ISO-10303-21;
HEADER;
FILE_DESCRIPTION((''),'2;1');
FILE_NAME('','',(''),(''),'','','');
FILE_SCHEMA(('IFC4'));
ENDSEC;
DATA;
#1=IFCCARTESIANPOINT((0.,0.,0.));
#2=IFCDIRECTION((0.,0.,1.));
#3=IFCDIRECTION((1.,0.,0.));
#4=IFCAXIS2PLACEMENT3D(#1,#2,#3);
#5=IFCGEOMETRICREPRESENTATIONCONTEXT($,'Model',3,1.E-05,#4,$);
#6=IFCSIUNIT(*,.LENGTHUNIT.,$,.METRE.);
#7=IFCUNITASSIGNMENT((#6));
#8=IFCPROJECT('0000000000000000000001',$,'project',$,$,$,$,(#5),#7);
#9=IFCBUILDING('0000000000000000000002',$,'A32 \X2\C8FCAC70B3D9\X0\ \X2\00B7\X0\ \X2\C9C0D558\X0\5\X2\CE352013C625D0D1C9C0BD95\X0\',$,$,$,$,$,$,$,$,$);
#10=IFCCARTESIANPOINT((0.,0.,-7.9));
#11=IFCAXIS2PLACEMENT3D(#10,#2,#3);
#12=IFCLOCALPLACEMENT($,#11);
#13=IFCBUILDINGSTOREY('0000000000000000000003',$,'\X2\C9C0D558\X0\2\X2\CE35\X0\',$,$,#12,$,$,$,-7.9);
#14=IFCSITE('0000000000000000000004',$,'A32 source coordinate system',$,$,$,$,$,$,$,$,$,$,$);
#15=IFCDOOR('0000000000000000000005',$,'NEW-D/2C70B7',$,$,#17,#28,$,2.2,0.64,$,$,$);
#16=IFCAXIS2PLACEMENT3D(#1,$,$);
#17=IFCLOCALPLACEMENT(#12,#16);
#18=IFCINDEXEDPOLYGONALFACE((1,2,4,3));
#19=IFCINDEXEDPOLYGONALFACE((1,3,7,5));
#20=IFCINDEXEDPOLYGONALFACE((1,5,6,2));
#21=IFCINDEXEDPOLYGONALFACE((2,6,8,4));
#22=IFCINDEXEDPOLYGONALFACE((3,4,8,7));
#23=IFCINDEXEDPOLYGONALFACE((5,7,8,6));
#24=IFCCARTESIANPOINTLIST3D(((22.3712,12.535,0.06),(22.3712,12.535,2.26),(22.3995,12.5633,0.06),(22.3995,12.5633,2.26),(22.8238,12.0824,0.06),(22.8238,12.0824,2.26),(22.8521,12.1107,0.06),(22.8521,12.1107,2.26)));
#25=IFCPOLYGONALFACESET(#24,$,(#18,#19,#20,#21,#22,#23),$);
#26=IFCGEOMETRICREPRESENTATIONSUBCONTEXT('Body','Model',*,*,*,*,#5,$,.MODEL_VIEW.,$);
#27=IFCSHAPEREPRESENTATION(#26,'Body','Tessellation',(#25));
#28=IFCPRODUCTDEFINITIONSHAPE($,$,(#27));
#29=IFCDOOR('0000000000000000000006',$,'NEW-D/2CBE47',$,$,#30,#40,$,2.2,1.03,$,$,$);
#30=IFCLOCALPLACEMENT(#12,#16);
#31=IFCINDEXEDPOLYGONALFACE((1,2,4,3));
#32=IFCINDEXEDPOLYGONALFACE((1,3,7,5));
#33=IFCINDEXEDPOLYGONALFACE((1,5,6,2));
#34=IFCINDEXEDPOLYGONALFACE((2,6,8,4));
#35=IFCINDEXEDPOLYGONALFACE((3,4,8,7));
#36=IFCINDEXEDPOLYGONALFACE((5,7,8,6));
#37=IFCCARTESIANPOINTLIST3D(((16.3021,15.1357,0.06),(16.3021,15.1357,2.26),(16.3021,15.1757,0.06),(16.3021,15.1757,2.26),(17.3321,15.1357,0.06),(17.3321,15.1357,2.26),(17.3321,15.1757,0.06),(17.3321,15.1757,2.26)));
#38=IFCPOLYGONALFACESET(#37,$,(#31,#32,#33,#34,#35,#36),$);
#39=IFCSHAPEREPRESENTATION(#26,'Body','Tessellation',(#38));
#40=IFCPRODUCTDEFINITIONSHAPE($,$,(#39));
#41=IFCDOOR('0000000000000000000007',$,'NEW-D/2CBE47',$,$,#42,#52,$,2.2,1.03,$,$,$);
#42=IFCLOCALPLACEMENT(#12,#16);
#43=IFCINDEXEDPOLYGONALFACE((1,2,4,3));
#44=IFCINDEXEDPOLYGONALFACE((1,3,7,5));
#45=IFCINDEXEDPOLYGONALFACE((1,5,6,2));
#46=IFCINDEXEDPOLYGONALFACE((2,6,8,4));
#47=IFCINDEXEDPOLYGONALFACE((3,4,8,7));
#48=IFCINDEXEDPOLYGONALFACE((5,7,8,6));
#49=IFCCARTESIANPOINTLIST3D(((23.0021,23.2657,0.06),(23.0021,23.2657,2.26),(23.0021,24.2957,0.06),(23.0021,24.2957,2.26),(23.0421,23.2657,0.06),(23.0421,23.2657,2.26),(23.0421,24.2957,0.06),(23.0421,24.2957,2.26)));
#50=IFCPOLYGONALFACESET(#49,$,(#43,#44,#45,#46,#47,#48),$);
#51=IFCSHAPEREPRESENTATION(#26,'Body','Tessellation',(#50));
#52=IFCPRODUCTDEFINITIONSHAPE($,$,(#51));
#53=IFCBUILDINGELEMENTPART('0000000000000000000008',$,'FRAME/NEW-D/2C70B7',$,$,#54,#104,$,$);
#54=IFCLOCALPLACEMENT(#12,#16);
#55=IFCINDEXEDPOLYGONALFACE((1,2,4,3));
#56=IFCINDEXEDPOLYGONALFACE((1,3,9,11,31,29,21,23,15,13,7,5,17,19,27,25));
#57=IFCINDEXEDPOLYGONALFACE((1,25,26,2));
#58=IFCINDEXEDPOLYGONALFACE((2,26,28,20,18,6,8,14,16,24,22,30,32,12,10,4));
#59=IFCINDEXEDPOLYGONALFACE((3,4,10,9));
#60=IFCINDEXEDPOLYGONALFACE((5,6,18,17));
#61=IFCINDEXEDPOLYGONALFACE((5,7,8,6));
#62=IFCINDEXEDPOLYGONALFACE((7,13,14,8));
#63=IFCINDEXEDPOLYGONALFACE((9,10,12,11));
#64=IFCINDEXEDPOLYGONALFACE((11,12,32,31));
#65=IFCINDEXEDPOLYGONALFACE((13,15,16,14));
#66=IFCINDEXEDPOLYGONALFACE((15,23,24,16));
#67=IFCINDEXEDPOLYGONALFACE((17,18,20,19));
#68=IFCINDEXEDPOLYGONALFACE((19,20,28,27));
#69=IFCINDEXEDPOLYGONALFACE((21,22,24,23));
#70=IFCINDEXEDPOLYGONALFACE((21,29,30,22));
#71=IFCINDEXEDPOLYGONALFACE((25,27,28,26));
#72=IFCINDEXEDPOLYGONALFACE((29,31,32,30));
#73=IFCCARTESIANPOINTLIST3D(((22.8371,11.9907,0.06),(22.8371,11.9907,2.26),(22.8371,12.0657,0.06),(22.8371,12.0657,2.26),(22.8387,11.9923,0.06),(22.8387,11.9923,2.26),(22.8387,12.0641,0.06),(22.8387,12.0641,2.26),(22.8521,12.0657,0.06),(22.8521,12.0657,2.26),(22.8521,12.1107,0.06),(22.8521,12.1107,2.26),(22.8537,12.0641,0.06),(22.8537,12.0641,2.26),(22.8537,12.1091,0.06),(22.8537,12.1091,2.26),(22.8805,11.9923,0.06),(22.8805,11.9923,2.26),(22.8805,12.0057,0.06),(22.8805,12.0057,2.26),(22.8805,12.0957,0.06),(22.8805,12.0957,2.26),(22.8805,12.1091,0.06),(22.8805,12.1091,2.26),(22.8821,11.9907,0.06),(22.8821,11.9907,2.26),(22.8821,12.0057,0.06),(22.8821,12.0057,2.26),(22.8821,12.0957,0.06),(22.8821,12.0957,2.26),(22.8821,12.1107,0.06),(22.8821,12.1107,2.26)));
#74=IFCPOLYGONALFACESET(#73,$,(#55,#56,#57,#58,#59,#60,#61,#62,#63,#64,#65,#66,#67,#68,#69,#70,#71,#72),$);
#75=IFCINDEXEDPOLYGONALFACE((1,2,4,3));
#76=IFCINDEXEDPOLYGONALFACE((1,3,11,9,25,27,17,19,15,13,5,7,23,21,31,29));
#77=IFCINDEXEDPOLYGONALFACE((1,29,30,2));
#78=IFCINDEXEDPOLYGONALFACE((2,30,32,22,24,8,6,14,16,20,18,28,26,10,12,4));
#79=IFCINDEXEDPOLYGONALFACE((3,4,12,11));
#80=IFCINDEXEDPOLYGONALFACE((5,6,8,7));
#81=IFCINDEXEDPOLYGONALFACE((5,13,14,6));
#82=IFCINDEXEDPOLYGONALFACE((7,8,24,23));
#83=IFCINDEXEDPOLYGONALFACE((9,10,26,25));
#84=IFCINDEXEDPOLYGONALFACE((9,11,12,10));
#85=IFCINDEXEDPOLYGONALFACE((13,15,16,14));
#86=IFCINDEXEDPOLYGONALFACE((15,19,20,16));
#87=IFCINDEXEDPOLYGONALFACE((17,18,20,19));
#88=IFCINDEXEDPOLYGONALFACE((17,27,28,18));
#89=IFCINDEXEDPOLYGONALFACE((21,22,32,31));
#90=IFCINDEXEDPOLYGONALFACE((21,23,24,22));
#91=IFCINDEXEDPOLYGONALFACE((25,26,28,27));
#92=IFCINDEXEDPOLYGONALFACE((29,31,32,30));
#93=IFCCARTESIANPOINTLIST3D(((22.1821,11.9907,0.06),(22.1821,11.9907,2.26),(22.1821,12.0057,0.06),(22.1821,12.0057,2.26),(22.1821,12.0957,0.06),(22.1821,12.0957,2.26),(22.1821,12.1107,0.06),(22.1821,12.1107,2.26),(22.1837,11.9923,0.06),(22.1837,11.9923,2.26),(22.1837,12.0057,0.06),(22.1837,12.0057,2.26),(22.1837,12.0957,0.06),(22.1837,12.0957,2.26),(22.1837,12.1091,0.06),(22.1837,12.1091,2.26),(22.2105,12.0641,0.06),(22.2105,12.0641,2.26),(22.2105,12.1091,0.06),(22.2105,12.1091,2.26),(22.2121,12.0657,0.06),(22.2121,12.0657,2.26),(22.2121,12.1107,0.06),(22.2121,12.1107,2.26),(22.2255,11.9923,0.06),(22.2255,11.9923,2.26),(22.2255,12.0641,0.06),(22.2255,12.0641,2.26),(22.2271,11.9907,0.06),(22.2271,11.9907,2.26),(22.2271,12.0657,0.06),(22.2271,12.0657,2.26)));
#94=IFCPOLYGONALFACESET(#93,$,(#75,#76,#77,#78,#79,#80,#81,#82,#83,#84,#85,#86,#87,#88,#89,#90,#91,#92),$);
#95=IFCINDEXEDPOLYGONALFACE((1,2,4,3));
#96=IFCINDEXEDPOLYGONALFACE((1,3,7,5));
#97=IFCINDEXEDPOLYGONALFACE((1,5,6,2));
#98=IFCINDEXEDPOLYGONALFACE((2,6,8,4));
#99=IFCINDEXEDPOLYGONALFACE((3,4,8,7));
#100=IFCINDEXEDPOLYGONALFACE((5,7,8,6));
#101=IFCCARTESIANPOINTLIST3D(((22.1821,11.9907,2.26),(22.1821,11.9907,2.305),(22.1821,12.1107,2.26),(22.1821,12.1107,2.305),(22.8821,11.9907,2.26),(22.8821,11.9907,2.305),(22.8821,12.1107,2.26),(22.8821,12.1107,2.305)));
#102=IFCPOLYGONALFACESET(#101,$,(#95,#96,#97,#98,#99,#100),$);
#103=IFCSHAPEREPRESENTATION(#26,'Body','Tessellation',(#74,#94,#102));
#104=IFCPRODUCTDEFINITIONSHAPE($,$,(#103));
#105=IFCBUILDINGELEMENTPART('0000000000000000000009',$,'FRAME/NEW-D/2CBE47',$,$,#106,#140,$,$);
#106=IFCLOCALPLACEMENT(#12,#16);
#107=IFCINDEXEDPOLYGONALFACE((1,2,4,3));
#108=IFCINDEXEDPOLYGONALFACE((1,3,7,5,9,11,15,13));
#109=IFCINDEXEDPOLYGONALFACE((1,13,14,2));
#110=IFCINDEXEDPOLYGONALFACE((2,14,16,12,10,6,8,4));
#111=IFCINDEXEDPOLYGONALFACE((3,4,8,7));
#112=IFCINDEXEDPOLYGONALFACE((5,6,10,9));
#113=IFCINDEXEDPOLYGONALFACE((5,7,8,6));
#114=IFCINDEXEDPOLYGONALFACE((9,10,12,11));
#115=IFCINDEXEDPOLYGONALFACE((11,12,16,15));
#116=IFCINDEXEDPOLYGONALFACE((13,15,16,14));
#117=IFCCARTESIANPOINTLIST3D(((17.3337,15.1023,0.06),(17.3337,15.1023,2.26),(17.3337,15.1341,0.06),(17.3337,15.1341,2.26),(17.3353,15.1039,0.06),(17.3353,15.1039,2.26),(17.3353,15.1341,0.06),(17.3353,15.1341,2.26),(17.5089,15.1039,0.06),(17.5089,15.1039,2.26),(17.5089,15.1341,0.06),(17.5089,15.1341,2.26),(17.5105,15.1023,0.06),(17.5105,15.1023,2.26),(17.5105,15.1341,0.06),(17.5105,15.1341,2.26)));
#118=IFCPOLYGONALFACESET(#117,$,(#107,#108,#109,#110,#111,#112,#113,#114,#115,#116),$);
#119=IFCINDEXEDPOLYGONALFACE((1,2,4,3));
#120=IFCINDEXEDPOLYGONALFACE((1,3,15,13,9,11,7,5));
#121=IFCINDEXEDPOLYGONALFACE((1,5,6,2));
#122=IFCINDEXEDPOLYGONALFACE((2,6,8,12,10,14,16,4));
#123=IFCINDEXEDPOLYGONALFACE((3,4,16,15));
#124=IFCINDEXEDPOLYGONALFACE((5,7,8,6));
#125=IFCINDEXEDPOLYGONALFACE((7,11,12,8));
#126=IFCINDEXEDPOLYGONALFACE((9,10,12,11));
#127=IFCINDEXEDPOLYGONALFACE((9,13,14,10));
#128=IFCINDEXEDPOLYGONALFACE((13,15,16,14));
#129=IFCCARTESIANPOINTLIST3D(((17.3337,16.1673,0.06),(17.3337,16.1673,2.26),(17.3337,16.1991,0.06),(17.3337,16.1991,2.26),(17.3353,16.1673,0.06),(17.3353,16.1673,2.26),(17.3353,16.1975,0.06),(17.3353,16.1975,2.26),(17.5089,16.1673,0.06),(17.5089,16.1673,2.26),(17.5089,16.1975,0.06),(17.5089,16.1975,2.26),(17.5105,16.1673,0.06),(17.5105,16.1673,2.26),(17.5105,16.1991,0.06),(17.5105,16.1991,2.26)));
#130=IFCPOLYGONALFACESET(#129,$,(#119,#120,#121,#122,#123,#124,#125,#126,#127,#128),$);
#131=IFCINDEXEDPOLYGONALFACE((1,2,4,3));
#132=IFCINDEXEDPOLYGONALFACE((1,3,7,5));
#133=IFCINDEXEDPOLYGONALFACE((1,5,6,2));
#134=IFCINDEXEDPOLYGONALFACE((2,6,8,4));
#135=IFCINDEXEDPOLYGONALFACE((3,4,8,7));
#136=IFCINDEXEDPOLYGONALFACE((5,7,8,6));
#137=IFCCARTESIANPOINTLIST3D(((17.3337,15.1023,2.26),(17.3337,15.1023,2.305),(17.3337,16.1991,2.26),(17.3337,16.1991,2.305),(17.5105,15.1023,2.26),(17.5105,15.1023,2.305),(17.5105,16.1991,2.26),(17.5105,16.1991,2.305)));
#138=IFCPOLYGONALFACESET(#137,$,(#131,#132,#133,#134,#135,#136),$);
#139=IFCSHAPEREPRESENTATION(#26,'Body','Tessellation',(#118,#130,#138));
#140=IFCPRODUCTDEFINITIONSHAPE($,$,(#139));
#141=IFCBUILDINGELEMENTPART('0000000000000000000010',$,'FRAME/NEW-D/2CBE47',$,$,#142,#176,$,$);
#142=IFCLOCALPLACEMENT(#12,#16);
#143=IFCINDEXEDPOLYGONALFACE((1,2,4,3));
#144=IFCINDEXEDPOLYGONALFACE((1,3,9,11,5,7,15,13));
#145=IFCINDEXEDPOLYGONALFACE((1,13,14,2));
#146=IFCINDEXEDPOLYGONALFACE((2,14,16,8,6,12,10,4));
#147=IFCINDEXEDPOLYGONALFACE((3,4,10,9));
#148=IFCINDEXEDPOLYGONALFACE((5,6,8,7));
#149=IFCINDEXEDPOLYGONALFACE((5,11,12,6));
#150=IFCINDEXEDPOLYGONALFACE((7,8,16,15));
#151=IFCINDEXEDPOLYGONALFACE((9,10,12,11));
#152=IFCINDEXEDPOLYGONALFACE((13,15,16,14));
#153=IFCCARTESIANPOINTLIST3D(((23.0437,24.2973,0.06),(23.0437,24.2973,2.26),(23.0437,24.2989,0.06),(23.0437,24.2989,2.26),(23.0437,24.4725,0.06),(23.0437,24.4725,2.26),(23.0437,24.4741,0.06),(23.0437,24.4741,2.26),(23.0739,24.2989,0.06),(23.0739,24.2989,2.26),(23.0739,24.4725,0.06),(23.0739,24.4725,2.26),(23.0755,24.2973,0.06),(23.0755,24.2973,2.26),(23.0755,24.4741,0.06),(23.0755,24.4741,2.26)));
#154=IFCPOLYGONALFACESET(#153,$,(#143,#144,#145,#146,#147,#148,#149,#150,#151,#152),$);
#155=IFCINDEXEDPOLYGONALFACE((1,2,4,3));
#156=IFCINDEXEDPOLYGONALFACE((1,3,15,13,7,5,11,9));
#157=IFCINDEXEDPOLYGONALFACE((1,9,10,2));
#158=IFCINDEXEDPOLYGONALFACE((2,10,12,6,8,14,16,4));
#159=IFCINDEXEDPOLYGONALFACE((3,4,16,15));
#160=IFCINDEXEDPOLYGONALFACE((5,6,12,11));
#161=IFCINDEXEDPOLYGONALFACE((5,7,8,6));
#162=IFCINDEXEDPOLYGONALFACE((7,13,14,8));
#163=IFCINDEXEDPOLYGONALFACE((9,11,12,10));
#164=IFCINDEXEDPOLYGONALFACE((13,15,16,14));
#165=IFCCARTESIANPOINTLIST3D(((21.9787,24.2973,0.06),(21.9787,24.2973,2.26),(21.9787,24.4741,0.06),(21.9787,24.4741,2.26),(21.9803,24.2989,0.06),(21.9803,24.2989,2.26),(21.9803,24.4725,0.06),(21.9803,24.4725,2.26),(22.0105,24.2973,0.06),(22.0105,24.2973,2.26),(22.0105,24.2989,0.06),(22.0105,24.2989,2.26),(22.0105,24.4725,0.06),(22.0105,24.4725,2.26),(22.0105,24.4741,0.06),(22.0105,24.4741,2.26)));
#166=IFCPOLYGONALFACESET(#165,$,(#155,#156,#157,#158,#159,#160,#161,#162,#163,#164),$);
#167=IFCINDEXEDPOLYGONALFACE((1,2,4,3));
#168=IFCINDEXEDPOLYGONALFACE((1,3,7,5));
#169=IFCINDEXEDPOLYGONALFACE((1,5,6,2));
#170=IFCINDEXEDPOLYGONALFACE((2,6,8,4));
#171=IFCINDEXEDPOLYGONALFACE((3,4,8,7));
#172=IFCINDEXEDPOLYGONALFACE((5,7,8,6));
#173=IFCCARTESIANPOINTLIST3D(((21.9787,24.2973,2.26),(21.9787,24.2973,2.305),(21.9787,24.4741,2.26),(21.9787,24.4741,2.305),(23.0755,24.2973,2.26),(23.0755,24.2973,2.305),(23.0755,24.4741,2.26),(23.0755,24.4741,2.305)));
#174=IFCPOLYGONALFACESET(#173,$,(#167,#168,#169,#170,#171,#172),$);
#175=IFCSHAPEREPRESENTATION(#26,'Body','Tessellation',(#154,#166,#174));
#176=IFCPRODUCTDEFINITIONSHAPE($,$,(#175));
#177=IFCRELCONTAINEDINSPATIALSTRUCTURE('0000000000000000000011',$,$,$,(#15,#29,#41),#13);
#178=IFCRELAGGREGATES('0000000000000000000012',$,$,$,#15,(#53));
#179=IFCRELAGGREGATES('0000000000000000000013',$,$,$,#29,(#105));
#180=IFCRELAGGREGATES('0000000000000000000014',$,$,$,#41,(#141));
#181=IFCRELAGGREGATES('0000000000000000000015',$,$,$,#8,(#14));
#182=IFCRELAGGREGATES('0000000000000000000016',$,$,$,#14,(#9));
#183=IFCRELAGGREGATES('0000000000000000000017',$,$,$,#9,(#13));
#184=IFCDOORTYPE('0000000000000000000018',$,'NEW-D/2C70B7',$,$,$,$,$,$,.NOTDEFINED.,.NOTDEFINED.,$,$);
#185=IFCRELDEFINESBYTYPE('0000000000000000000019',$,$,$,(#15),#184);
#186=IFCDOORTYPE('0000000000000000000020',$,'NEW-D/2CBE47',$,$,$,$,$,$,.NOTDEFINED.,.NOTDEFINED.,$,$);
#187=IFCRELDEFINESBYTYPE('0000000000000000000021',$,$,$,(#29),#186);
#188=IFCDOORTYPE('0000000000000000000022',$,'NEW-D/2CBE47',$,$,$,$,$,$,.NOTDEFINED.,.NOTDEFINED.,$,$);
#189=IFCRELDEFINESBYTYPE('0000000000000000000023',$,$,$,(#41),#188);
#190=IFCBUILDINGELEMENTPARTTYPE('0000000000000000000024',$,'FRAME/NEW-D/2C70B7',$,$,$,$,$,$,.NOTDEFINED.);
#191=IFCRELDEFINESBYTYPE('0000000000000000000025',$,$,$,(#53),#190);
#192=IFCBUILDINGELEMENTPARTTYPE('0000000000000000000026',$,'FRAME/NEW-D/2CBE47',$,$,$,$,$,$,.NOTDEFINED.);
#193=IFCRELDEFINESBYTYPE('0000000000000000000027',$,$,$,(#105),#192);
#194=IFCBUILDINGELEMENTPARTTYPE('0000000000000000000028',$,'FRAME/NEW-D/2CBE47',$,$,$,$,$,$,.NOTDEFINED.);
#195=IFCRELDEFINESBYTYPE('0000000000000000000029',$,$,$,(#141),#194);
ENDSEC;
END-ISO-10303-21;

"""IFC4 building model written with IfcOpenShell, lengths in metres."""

from ifc_helpers import new_model, si_unit, frame, origin, origin_with_axes, place, context, subcontext, project, spatial, polyline, outline, extrude, source, transform, mapped, type_object, type_shapes, element, aggregate, save


model = new_model("IFC4")

# Units and contexts
model_context = context("Model", 3, precision=1e-05, world=origin_with_axes())
body_context = subcontext(model_context, "Body", "Model", "MODEL_VIEW")
ifc_project = project(units=[si_unit("LENGTHUNIT", "METRE")], contexts=[model_context])

# Site, building, storey
site = spatial("IfcSite", under=ifc_project, Name="A32 source coordinate system")
building = spatial("IfcBuilding", under=site, Name="A32 주거동 · 지하5층–옥탑지붕")
storey_placement = place(None, frame((0.0, 0.0, -7.9), z_axis=(0.0, 0.0, 1.0), x_axis=(1.0, 0.0, 0.0)))
storey = spatial("IfcBuildingStorey", under=building, at=storey_placement, Name="지하2층", Elevation=-7.9)

# Doors
door_type_1 = type_object("IfcDoorType", Name="NEW-D/2C70B7", OperationType="NOTDEFINED", PredefinedType="NOTDEFINED")
shared_shape_1 = source(origin(), body_context, "Body", "SweptSolid", [
    extrude(outline(polyline([(22.8521, 12.1107), (22.8238, 12.0824), (22.3712, 12.535), (22.3995, 12.5633), (22.8521, 12.1107)])), frame((0.0, 0.0, 0.06)), (0.0, 0.0, 1.0), 2.2),
])
type_shapes(door_type_1, [shared_shape_1])
door_1_placement = place(storey_placement, origin_with_axes())
door_1 = element("IfcDoor", 1, at=door_1_placement, inside=storey, type_object=door_type_1, Name="NEW-D/2C70B7", OverallHeight=2.2, OverallWidth=0.64, context=body_context, shape_type="MappedRepresentation", body=[
    mapped(shared_shape_1, transform((0.0, 0.0, 0.0), scale=1.0)),
])
door_type_2 = type_object("IfcDoorType", Name="NEW-D/2CBE47", OperationType="NOTDEFINED", PredefinedType="NOTDEFINED")
shared_shape_2 = source(origin(), body_context, "Body", "SweptSolid", [
    extrude(outline(polyline([(16.3021, 15.1757), (17.3321, 15.1757), (17.3321, 15.1357), (16.3021, 15.1357), (16.3021, 15.1757)])), frame((0.0, 0.0, 0.06)), (0.0, 0.0, 1.0), 2.2),
])
type_shapes(door_type_2, [shared_shape_2])
door_2_placement = place(storey_placement, origin_with_axes())
door_2 = element("IfcDoor", 2, at=door_2_placement, inside=storey, type_object=door_type_2, Name="NEW-D/2CBE47", OverallHeight=2.2, OverallWidth=1.03, context=body_context, shape_type="MappedRepresentation", body=[
    mapped(shared_shape_2, transform((0.0, 0.0, 0.0), scale=1.0)),
])
door_type_3 = type_object("IfcDoorType", Name="NEW-D/2CBE47", OperationType="NOTDEFINED", PredefinedType="NOTDEFINED")
shared_shape_3 = source(origin(), body_context, "Body", "SweptSolid", [
    extrude(outline(polyline([(23.0021, 23.2657), (23.0021, 24.2957), (23.0421, 24.2957), (23.0421, 23.2657), (23.0021, 23.2657)])), frame((0.0, 0.0, 0.06)), (0.0, 0.0, 1.0), 2.2),
])
type_shapes(door_type_3, [shared_shape_3])
door_3_placement = place(storey_placement, origin_with_axes())
door_3 = element("IfcDoor", 3, at=door_3_placement, inside=storey, type_object=door_type_3, Name="NEW-D/2CBE47", OverallHeight=2.2, OverallWidth=1.03, context=body_context, shape_type="MappedRepresentation", body=[
    mapped(shared_shape_3, transform((0.0, 0.0, 0.0), scale=1.0)),
])

# Building element parts
building_element_part_type_1 = type_object("IfcBuildingElementPartType", Name="FRAME/NEW-D/2C70B7", PredefinedType="NOTDEFINED")
shared_shape_4 = source(origin(), body_context, "Body", "SweptSolid", [
    extrude(outline(polyline([(22.8537, 12.1091), (22.8537, 12.0641), (22.8387, 12.0641), (22.8387, 11.9923), (22.8805, 11.9923), (22.8805, 12.0057), (22.8821, 12.0057), (22.8821, 11.9907), (22.8371, 11.9907), (22.8371, 12.0657), (22.8521, 12.0657), (22.8521, 12.1107), (22.8821, 12.1107), (22.8821, 12.0957), (22.8805, 12.0957), (22.8805, 12.1091), (22.8537, 12.1091)])), frame((0.0, 0.0, 0.06)), (0.0, 0.0, 1.0), 2.2),
    extrude(outline(polyline([(22.1821, 12.1107), (22.2121, 12.1107), (22.2121, 12.0657), (22.2271, 12.0657), (22.2271, 11.9907), (22.1821, 11.9907), (22.1821, 12.0057), (22.1837, 12.0057), (22.1837, 11.9923), (22.2255, 11.9923), (22.2255, 12.0641), (22.2105, 12.0641), (22.2105, 12.1091), (22.1837, 12.1091), (22.1837, 12.0957), (22.1821, 12.0957), (22.1821, 12.1107)])), frame((0.0, 0.0, 0.06)), (0.0, 0.0, 1.0), 2.2),
    extrude(outline(polyline([(22.8821, 11.9907), (22.8821, 12.1107), (22.1821, 12.1107), (22.1821, 11.9907), (22.8821, 11.9907)])), frame((0.0, 0.0, 2.26)), (0.0, 0.0, 1.0), 0.045),
])
type_shapes(building_element_part_type_1, [shared_shape_4])
building_element_part_1_placement = place(door_1_placement, origin_with_axes())
building_element_part_1 = element("IfcBuildingElementPart", 4, at=building_element_part_1_placement, type_object=building_element_part_type_1, Name="FRAME/NEW-D/2C70B7", context=body_context, shape_type="MappedRepresentation", body=[
    mapped(shared_shape_4, transform((0.0, 0.0, 0.0), scale=1.0)),
])
aggregate(door_1, [building_element_part_1])
building_element_part_type_2 = type_object("IfcBuildingElementPartType", Name="FRAME/NEW-D/2CBE47", PredefinedType="NOTDEFINED")
shared_shape_5 = source(origin(), body_context, "Body", "SweptSolid", [
    extrude(outline(polyline([(17.3353, 15.1039), (17.5089, 15.1039), (17.5089, 15.1341), (17.5105, 15.1341), (17.5105, 15.1023), (17.3337, 15.1023), (17.3337, 15.1341), (17.3353, 15.1341), (17.3353, 15.1039)])), frame((0.0, 0.0, 0.06)), (0.0, 0.0, 1.0), 2.2),
    extrude(outline(polyline([(17.5105, 16.1991), (17.5105, 16.1673), (17.5089, 16.1673), (17.5089, 16.1975), (17.3353, 16.1975), (17.3353, 16.1673), (17.3337, 16.1673), (17.3337, 16.1991), (17.5105, 16.1991)])), frame((0.0, 0.0, 0.06)), (0.0, 0.0, 1.0), 2.2),
    extrude(outline(polyline([(17.5105, 15.1023), (17.5105, 16.1991), (17.3337, 16.1991), (17.3337, 15.1023), (17.5105, 15.1023)])), frame((0.0, 0.0, 2.26)), (0.0, 0.0, 1.0), 0.045),
])
type_shapes(building_element_part_type_2, [shared_shape_5])
building_element_part_2_placement = place(door_2_placement, origin_with_axes())
building_element_part_2 = element("IfcBuildingElementPart", 5, at=building_element_part_2_placement, type_object=building_element_part_type_2, Name="FRAME/NEW-D/2CBE47", context=body_context, shape_type="MappedRepresentation", body=[
    mapped(shared_shape_5, transform((0.0, 0.0, 0.0), scale=1.0)),
])
aggregate(door_2, [building_element_part_2])
building_element_part_type_3 = type_object("IfcBuildingElementPartType", Name="FRAME/NEW-D/2CBE47", PredefinedType="NOTDEFINED")
shared_shape_6 = source(origin(), body_context, "Body", "SweptSolid", [
    extrude(outline(polyline([(23.0739, 24.2989), (23.0739, 24.4725), (23.0437, 24.4725), (23.0437, 24.4741), (23.0755, 24.4741), (23.0755, 24.2973), (23.0437, 24.2973), (23.0437, 24.2989), (23.0739, 24.2989)])), frame((0.0, 0.0, 0.06)), (0.0, 0.0, 1.0), 2.2),
    extrude(outline(polyline([(21.9787, 24.4741), (22.0105, 24.4741), (22.0105, 24.4725), (21.9803, 24.4725), (21.9803, 24.2989), (22.0105, 24.2989), (22.0105, 24.2973), (21.9787, 24.2973), (21.9787, 24.4741)])), frame((0.0, 0.0, 0.06)), (0.0, 0.0, 1.0), 2.2),
    extrude(outline(polyline([(23.0755, 24.2973), (23.0755, 24.4741), (21.9787, 24.4741), (21.9787, 24.2973), (23.0755, 24.2973)])), frame((0.0, 0.0, 2.26)), (0.0, 0.0, 1.0), 0.045),
])
type_shapes(building_element_part_type_3, [shared_shape_6])
building_element_part_3_placement = place(door_3_placement, origin_with_axes())
building_element_part_3 = element("IfcBuildingElementPart", 6, at=building_element_part_3_placement, type_object=building_element_part_type_3, Name="FRAME/NEW-D/2CBE47", context=body_context, shape_type="MappedRepresentation", body=[
    mapped(shared_shape_6, transform((0.0, 0.0, 0.0), scale=1.0)),
])
aggregate(door_3, [building_element_part_3])

save(model, "model.ifc")
